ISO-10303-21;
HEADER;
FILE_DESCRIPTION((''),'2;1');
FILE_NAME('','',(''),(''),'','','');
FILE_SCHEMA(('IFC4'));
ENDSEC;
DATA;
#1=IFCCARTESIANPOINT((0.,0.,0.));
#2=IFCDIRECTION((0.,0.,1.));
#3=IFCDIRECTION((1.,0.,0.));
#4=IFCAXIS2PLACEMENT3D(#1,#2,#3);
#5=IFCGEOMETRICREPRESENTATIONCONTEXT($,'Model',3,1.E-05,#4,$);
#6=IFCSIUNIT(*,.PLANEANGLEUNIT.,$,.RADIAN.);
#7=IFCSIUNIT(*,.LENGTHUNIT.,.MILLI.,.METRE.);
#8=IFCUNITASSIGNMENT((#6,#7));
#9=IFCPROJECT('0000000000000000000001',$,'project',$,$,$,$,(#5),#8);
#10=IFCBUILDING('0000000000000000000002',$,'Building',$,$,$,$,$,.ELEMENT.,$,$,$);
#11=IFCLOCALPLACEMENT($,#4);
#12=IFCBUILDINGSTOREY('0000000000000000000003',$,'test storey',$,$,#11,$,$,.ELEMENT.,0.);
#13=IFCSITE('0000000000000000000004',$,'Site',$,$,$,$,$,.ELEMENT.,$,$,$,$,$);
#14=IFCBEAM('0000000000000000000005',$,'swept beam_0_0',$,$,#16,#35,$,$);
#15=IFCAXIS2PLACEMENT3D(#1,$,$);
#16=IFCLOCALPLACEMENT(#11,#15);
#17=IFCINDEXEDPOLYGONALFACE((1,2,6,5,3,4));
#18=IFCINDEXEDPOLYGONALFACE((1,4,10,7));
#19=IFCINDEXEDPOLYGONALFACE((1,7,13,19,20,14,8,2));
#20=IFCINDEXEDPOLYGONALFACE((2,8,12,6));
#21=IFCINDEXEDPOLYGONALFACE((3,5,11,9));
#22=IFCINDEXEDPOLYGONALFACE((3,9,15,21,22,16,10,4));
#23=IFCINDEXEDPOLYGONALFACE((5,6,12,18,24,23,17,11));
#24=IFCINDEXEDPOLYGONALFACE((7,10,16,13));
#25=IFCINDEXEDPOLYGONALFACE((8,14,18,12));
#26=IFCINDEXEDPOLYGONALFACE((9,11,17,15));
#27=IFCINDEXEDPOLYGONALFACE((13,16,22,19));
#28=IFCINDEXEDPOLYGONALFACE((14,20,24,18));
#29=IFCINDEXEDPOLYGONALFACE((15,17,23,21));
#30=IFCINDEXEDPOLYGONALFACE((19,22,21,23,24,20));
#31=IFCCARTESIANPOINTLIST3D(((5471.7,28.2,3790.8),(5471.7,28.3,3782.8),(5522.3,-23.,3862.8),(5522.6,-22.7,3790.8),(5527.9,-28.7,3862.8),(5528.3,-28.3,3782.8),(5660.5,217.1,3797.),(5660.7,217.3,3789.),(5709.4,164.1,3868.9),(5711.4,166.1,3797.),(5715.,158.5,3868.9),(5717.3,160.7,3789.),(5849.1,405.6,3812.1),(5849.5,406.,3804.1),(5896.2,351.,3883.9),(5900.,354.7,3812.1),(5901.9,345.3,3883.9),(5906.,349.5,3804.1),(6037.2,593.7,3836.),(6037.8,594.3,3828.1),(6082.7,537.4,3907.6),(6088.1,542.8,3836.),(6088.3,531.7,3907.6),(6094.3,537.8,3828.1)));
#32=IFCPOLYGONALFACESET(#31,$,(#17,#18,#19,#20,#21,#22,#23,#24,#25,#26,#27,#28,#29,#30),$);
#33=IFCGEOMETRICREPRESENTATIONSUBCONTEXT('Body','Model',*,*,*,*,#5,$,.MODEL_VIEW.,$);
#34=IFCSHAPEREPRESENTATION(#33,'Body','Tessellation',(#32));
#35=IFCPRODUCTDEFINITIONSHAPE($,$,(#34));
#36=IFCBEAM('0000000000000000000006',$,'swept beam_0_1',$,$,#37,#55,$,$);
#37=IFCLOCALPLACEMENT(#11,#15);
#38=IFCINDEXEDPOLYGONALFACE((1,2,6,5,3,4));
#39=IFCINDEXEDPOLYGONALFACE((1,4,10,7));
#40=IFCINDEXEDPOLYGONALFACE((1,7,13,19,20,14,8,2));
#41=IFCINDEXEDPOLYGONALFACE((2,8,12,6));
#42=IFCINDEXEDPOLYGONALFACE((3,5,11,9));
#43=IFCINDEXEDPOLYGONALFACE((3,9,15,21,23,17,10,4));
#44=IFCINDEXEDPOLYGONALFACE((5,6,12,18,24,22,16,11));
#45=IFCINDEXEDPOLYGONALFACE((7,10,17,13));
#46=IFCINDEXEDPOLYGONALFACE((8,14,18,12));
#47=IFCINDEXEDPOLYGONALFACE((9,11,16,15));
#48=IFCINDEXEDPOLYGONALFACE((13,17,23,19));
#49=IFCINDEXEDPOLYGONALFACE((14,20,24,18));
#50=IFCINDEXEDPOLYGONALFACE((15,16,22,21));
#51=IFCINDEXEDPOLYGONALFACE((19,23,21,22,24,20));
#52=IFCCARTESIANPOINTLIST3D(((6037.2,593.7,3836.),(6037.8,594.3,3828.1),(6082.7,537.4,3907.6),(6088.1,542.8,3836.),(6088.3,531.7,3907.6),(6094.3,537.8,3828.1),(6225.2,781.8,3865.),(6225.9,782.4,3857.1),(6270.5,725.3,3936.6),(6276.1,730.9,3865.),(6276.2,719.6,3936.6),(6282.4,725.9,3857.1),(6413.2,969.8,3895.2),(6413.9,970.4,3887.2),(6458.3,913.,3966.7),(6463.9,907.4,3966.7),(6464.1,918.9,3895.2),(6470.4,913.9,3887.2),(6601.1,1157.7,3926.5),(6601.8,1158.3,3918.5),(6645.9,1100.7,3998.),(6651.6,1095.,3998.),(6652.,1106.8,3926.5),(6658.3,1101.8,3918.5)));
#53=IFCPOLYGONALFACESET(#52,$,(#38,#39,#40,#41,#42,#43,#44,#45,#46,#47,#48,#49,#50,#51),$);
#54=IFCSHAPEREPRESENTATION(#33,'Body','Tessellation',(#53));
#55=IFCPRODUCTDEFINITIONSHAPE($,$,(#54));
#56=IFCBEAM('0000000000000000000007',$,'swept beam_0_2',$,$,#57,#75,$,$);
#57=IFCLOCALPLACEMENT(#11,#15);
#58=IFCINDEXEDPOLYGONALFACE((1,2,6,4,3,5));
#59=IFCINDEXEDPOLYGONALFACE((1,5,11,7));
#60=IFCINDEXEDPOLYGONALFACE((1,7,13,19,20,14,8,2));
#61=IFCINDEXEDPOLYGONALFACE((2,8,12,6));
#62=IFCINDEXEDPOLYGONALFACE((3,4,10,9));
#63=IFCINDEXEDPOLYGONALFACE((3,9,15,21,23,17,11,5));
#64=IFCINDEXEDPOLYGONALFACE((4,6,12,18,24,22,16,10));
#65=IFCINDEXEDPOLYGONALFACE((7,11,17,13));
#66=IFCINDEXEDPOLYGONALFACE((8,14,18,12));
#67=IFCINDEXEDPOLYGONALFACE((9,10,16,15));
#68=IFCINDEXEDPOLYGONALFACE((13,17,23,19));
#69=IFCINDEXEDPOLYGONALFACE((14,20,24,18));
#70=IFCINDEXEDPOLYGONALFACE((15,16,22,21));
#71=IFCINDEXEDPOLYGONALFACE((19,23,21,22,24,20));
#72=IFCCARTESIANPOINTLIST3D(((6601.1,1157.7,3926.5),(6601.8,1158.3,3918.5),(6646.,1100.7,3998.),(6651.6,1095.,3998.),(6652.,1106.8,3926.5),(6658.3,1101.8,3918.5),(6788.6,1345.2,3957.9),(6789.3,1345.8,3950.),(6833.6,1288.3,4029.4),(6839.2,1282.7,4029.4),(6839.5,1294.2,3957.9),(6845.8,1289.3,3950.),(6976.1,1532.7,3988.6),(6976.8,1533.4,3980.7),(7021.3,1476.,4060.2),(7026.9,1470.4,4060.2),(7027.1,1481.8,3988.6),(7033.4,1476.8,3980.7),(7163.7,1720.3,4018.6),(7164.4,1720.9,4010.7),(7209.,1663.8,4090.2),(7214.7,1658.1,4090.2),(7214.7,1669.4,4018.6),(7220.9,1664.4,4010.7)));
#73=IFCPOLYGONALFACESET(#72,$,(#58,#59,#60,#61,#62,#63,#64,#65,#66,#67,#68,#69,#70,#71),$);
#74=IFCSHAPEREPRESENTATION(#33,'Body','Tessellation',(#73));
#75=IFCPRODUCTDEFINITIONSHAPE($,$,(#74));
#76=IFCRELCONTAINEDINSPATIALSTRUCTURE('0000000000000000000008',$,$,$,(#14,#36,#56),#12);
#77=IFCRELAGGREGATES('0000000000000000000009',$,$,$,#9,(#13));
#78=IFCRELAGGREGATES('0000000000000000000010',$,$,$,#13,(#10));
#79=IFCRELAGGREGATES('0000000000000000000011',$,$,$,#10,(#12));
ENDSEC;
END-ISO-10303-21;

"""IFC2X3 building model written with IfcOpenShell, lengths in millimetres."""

from ifc_helpers import new_model, entity, si_unit, origin_with_axes, place, context, subcontext, project, spatial, element, save


model = new_model("IFC2X3")

# Units and contexts
model_context = context("Model", 3, precision=1e-05, world=origin_with_axes())
body_context = subcontext(model_context, "Body", "Model", "MODEL_VIEW")
ifc_project = project(units=[si_unit("PLANEANGLEUNIT", "RADIAN"), si_unit("LENGTHUNIT", "METRE", prefix="MILLI")], contexts=[model_context])

# Site, building, storey
site = spatial("IfcSite", under=ifc_project, Name="Site", CompositionType="ELEMENT")
building = spatial("IfcBuilding", under=site, Name="Building", CompositionType="ELEMENT")
storey_placement = place(None, origin_with_axes())
storey = spatial("IfcBuildingStorey", under=building, at=storey_placement, Name="test storey", CompositionType="ELEMENT", Elevation=0.0)

# Beams
beam_1_placement = place(storey_placement, origin_with_axes())
element("IfcBeam", 1, at=beam_1_placement, inside=storey, Name="swept beam_0_0", context=body_context, shape_type="SweptSolid", body=[
    entity("IfcRevolvedAreaSolid", entity("IfcArbitraryClosedProfileDef", "AREA", None, entity("IfcPolyline", [entity("IfcCartesianPoint", [-80.0, 40.0]), entity("IfcCartesianPoint", [-80.0, 32.0]), entity("IfcCartesianPoint", [-8.0, 32.0]), entity("IfcCartesianPoint", [-8.0, -40.0]), entity("IfcCartesianPoint", [0.0, -40.0]), entity("IfcCartesianPoint", [0.0, 40.0]), entity("IfcCartesianPoint", [-80.0, 40.0])])), entity("IfcAxis2Placement3D", entity("IfcCartesianPoint", [5500.0, 0.0, 3782.8]), entity("IfcDirection", [-0.7071, -0.7071, -0.0066]), entity("IfcDirection", [0.0046, 0.0046, -1.0])), entity("IfcAxis1Placement", entity("IfcCartesianPoint", [-8028.3, 0.0, 0.0]), entity("IfcDirection", [0.0, 1.0, 0.0])), 0.099911),
])
beam_2_placement = place(storey_placement, origin_with_axes())
element("IfcBeam", 2, at=beam_2_placement, inside=storey, Name="swept beam_0_1", context=body_context, shape_type="SweptSolid", body=[
    entity("IfcRevolvedAreaSolid", entity("IfcArbitraryClosedProfileDef", "AREA", None, entity("IfcPolyline", [entity("IfcCartesianPoint", [-80.0, 40.0]), entity("IfcCartesianPoint", [-80.0, 32.0]), entity("IfcCartesianPoint", [-8.0, 32.0]), entity("IfcCartesianPoint", [-8.0, -40.0]), entity("IfcCartesianPoint", [0.0, -40.0]), entity("IfcCartesianPoint", [0.0, 40.0]), entity("IfcCartesianPoint", [-80.0, 40.0])])), entity("IfcAxis2Placement3D", entity("IfcCartesianPoint", [6066.0, 566.0, 3828.1]), entity("IfcDirection", [-0.7031, -0.7031, -0.1063]), entity("IfcDirection", [0.0752, 0.0752, -0.9943])), entity("IfcAxis1Placement", entity("IfcCartesianPoint", [-62029.6, 0.0, 0.0]), entity("IfcDirection", [0.0, 1.0, 0.0])), 0.012942),
])
beam_3_placement = place(storey_placement, origin_with_axes())
element("IfcBeam", 3, at=beam_3_placement, inside=storey, Name="swept beam_0_2", context=body_context, shape_type="SweptSolid", body=[
    entity("IfcRevolvedAreaSolid", entity("IfcArbitraryClosedProfileDef", "AREA", None, entity("IfcPolyline", [entity("IfcCartesianPoint", [80.0, -40.0]), entity("IfcCartesianPoint", [80.0, -32.0]), entity("IfcCartesianPoint", [8.0, -32.0]), entity("IfcCartesianPoint", [8.0, 40.0]), entity("IfcCartesianPoint", [0.0, 40.0]), entity("IfcCartesianPoint", [0.0, -40.0]), entity("IfcCartesianPoint", [80.0, -40.0])])), entity("IfcAxis2Placement3D", entity("IfcCartesianPoint", [6630.1, 1130.1, 3918.5]), entity("IfcDirection", [-0.7021, -0.7021, -0.1191]), entity("IfcDirection", [-0.0842, -0.0842, 0.9929])), entity("IfcAxis1Placement", entity("IfcCartesianPoint", [-97641.5, 0.0, 0.0]), entity("IfcDirection", [0.0, 1.0, 0.0])), 0.008203),
])

save(model, "model.ifc")
